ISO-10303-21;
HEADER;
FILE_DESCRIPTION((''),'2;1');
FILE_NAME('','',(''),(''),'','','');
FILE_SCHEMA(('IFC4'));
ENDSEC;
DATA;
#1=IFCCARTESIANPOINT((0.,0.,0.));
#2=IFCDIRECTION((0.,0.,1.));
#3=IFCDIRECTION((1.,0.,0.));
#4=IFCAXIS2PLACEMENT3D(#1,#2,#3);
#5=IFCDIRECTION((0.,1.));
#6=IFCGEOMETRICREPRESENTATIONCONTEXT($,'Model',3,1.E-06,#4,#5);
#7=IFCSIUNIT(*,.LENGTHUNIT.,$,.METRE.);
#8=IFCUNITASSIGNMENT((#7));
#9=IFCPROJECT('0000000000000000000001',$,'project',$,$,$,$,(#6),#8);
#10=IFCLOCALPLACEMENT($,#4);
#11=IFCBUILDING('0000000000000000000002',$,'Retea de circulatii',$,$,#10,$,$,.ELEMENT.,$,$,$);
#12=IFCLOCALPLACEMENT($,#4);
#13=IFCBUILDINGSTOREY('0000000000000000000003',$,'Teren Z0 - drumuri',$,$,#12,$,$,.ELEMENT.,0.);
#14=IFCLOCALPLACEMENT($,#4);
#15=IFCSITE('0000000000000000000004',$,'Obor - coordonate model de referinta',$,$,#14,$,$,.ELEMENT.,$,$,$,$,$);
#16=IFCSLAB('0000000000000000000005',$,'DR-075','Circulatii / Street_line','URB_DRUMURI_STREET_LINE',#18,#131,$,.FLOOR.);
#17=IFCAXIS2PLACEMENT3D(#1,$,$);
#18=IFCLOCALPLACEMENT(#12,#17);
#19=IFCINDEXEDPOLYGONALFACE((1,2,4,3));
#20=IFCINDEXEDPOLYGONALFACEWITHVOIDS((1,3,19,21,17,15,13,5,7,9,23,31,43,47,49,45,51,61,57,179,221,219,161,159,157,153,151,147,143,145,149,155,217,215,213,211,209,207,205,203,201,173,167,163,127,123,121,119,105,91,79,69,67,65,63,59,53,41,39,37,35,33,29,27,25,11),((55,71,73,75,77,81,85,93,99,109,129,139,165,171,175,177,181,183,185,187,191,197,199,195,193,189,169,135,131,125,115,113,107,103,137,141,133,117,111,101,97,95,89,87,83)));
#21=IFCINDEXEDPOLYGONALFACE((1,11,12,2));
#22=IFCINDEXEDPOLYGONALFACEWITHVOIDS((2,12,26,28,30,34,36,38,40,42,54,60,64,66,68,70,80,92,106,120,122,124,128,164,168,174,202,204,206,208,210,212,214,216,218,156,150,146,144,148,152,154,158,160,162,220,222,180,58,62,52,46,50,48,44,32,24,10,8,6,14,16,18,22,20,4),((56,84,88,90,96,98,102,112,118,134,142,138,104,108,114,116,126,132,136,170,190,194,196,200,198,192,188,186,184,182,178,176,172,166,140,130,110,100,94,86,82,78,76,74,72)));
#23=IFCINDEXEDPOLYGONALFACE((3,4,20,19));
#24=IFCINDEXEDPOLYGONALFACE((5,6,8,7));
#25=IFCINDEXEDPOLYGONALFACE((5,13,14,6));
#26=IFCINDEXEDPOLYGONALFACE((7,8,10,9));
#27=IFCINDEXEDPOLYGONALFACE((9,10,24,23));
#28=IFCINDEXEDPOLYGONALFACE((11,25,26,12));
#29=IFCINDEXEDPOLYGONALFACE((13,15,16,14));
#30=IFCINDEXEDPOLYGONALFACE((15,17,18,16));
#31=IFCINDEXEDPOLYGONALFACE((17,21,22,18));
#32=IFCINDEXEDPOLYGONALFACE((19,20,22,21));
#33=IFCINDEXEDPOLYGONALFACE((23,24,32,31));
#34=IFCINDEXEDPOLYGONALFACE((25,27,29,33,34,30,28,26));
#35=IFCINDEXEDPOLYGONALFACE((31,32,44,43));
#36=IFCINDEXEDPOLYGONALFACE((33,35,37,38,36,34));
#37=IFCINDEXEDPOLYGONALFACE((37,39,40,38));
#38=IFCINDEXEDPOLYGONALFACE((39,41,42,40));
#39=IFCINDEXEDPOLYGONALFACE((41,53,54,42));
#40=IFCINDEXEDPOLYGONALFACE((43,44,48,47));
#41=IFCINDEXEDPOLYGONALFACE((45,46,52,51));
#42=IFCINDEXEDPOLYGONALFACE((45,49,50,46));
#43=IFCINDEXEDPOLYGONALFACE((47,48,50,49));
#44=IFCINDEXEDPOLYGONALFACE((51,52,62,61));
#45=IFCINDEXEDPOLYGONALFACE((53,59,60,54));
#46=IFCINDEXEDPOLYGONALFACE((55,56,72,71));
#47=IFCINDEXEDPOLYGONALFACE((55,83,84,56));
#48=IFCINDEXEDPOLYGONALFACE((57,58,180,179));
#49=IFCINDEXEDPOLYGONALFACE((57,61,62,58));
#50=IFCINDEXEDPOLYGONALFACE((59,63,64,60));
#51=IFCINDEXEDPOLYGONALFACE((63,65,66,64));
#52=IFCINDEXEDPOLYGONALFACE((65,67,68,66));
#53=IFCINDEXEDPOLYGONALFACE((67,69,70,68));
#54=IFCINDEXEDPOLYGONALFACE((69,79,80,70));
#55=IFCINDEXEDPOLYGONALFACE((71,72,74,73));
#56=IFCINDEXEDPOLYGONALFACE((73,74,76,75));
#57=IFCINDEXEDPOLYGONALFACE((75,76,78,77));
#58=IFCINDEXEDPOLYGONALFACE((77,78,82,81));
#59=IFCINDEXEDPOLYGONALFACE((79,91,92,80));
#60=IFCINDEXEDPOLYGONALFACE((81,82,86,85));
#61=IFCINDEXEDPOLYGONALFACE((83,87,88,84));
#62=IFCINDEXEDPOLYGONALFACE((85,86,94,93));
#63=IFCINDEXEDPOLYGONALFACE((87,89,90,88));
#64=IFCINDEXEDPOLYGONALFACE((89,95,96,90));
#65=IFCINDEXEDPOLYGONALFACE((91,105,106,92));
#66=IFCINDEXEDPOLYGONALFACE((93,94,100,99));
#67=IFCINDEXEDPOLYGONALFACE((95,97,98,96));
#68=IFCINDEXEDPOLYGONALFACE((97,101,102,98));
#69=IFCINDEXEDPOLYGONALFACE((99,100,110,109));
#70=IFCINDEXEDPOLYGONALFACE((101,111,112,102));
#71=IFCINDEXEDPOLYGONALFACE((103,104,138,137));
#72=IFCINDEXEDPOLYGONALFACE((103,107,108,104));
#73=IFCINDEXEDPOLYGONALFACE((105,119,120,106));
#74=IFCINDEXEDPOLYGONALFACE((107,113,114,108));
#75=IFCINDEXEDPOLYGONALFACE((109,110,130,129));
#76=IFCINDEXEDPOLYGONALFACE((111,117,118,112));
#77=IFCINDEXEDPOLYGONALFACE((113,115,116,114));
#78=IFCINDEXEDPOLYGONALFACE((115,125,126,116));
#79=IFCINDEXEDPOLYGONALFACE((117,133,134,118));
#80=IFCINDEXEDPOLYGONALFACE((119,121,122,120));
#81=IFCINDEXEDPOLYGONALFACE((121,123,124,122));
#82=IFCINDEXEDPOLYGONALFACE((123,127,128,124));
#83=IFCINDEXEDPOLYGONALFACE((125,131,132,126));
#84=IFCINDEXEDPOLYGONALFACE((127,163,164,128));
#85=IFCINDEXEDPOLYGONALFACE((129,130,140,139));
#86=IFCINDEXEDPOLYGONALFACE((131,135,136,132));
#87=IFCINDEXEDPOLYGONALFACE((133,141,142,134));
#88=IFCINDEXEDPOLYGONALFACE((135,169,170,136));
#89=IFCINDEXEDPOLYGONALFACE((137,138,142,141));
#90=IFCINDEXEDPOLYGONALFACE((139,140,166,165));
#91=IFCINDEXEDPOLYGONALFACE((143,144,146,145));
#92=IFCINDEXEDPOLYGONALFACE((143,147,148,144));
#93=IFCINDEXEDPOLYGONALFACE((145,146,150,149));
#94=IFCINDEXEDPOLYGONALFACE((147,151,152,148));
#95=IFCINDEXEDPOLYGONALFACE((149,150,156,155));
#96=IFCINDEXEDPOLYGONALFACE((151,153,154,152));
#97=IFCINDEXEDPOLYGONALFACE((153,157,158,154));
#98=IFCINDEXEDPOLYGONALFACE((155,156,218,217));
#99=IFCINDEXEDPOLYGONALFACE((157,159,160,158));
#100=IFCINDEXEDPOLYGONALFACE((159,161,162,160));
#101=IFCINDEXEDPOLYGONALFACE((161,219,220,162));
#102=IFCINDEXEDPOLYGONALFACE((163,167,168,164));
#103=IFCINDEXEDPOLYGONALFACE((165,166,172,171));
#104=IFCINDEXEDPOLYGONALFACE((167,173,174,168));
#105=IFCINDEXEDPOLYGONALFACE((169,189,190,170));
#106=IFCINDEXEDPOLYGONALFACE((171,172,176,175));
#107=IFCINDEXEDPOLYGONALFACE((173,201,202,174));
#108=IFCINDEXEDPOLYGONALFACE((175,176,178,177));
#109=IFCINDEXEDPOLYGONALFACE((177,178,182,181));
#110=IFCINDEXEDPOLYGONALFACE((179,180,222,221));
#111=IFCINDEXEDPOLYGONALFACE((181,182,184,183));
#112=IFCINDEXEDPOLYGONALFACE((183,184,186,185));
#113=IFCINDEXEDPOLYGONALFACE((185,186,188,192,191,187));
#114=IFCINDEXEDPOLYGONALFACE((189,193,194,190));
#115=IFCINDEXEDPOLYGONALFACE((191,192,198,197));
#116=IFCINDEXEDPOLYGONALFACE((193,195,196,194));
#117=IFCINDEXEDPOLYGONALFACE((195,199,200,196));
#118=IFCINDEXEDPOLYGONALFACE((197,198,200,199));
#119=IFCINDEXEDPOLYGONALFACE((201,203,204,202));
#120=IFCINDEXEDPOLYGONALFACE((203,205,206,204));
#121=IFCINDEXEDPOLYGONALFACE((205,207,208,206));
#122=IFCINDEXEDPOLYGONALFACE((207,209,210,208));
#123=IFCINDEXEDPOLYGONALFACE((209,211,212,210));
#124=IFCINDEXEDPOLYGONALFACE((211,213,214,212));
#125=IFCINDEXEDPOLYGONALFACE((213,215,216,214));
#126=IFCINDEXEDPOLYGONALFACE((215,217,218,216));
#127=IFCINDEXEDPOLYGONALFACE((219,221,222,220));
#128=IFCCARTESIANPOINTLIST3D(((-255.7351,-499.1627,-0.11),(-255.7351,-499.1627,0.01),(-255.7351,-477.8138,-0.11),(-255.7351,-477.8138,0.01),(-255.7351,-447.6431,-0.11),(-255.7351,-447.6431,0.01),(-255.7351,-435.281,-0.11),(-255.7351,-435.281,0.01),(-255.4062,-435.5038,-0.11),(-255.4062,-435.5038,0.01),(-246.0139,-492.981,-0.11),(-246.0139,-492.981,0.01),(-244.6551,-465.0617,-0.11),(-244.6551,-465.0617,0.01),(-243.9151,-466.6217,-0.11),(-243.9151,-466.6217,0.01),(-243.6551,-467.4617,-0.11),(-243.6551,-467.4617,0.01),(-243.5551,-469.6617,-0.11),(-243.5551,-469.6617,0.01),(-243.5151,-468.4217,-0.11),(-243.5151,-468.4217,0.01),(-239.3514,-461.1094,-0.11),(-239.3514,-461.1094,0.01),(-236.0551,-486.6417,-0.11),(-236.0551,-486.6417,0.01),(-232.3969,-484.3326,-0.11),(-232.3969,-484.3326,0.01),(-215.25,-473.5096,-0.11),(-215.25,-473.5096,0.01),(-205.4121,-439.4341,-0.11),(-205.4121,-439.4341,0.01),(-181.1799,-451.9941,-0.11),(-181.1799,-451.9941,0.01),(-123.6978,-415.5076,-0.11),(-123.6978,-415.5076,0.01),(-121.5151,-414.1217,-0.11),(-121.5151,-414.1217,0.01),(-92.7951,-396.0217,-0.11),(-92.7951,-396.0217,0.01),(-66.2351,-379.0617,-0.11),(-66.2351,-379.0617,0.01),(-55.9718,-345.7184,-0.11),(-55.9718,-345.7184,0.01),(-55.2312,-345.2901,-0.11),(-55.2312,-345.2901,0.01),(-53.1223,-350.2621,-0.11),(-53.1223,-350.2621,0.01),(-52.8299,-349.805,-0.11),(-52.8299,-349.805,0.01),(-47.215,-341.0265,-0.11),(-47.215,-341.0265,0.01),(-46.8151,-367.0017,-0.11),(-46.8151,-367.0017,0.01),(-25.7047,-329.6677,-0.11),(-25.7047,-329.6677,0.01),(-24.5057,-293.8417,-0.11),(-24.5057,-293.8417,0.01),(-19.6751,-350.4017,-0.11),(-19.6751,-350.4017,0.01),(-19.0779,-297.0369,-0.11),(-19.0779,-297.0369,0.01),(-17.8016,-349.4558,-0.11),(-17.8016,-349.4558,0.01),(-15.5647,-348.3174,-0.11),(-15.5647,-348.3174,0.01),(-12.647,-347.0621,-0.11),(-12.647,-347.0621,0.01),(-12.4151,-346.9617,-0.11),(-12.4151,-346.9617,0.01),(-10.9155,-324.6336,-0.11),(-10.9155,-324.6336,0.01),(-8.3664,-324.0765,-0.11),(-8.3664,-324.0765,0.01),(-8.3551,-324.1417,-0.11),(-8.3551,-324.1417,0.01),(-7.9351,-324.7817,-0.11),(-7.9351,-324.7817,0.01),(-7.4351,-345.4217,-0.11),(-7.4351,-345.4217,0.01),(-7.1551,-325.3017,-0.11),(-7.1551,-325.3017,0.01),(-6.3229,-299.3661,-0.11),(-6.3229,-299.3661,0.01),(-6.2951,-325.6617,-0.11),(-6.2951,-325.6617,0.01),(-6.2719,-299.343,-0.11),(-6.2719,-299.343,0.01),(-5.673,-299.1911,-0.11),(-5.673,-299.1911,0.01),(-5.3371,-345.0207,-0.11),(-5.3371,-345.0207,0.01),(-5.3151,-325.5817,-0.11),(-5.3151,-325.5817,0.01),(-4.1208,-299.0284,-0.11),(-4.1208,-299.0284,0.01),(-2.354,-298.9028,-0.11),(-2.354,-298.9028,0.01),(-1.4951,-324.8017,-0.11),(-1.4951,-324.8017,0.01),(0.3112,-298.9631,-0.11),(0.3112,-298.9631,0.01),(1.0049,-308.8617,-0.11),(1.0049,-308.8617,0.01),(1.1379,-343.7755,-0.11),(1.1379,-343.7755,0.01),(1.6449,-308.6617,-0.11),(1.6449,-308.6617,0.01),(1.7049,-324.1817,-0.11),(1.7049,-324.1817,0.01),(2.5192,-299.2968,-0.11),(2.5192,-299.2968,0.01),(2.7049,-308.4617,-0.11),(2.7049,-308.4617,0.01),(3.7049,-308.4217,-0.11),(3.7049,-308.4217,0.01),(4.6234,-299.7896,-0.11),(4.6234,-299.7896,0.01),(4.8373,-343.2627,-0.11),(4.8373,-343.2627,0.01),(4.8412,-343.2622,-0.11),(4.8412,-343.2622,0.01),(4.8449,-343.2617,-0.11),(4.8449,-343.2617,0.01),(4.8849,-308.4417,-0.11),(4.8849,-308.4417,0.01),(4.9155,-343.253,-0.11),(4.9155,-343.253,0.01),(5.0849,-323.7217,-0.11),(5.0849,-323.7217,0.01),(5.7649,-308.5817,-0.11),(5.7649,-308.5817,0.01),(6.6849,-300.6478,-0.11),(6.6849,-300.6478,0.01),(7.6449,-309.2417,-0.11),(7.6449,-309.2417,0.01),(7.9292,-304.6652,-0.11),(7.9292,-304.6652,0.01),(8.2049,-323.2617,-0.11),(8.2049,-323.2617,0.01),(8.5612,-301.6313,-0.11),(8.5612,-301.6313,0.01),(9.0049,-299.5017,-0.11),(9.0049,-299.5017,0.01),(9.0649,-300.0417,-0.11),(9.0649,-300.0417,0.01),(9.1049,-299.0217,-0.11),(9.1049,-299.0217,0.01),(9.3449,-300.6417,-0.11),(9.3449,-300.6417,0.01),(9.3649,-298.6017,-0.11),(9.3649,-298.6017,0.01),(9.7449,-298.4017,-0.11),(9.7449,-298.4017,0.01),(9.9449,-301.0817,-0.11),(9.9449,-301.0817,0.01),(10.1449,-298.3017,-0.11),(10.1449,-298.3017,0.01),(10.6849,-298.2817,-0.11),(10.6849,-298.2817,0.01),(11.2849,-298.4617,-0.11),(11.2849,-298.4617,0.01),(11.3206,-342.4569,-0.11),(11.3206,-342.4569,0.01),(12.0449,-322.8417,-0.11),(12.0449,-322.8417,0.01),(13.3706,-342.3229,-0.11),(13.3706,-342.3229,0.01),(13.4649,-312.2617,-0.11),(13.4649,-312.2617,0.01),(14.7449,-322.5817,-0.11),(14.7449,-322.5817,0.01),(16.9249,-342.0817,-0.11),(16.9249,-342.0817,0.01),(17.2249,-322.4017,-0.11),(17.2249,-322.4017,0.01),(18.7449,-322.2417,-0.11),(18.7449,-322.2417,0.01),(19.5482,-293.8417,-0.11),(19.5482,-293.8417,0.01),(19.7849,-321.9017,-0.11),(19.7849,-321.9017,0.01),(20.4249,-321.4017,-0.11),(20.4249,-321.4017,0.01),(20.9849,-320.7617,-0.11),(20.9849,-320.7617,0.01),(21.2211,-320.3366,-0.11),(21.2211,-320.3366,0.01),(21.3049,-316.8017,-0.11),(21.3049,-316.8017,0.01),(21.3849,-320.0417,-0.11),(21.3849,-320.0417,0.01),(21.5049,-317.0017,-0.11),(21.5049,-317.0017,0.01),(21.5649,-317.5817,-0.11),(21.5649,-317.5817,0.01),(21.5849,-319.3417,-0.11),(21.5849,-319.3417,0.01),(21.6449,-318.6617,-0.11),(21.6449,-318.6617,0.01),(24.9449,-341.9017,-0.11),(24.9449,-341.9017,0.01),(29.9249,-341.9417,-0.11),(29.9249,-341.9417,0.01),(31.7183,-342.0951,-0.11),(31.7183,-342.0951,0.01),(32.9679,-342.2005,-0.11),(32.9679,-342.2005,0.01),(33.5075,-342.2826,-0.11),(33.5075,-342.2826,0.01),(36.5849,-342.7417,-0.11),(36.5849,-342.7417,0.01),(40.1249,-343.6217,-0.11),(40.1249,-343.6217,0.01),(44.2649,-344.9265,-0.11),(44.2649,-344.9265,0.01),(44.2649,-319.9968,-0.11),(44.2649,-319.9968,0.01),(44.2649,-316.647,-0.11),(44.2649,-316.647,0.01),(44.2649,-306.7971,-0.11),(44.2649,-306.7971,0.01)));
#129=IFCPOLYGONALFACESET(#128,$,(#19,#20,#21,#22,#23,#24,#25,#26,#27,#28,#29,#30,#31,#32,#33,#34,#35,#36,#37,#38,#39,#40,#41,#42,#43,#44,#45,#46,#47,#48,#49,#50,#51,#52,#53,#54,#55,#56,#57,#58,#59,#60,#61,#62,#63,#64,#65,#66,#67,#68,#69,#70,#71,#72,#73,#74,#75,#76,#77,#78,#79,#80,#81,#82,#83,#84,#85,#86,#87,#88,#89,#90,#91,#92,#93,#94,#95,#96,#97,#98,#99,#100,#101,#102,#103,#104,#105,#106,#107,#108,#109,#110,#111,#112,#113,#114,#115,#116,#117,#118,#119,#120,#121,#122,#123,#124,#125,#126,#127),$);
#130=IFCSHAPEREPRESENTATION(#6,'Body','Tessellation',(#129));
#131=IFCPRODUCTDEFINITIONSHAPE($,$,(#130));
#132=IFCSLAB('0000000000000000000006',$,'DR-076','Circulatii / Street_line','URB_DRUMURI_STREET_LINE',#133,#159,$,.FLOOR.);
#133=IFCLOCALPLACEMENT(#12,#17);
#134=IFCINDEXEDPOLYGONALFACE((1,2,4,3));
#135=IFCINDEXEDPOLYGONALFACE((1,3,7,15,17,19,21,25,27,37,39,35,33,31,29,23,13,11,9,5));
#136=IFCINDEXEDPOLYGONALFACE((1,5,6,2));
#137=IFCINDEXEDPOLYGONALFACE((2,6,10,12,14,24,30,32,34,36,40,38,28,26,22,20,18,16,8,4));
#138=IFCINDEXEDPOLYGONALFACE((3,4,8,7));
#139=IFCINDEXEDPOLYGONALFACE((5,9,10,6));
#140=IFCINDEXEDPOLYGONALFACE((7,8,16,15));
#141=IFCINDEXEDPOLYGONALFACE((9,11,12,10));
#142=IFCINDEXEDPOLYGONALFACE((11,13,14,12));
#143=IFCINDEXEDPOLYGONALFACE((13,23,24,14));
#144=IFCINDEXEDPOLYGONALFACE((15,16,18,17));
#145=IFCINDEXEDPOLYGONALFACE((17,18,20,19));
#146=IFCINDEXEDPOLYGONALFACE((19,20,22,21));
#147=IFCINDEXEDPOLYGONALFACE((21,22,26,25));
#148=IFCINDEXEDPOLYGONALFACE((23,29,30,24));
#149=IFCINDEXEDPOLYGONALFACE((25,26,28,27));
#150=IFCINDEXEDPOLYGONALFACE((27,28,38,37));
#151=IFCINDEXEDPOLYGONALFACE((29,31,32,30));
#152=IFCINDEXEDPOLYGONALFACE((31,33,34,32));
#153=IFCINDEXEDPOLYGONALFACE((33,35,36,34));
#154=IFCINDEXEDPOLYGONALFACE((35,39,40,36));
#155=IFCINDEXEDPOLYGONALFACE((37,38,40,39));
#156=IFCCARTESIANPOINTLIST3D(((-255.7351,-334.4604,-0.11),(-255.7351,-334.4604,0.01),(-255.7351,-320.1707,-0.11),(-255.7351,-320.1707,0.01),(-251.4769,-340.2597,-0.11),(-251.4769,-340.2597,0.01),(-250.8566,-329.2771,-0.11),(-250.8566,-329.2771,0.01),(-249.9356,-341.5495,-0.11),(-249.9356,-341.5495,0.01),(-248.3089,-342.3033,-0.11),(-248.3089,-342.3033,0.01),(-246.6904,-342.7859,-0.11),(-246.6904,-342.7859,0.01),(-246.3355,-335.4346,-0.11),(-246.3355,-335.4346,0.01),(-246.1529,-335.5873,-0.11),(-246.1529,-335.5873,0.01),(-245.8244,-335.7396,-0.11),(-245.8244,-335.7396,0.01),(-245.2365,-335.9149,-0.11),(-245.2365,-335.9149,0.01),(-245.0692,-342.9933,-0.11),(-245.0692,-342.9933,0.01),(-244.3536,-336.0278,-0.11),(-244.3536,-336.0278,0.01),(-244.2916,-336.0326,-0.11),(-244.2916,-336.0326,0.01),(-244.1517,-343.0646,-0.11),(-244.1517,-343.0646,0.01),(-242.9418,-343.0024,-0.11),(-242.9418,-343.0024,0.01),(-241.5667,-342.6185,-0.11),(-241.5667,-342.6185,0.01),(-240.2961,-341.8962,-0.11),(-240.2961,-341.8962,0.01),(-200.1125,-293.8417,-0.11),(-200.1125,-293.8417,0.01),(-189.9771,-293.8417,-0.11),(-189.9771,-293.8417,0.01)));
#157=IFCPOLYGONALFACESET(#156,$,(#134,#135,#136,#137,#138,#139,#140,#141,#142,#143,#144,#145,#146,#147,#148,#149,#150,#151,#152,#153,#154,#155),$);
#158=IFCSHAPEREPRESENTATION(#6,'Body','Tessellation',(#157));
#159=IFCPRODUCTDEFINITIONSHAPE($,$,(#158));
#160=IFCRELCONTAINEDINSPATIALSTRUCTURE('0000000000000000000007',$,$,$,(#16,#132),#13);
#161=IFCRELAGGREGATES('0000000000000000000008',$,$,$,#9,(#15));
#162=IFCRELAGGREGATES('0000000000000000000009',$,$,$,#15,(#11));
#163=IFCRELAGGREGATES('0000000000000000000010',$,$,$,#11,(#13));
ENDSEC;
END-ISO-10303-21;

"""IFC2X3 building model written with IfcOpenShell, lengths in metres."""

from ifc_helpers import new_model, si_unit, direction, frame, origin_with_axes, place, context, project, spatial, polyline, outline, extrude, element, save


model = new_model("IFC2X3")

# Units and contexts
model_context = context("Model", 3, precision=1e-06, world=origin_with_axes(), true_north=direction((0.0, 1.0)))
ifc_project = project(units=[si_unit("LENGTHUNIT", "METRE")], contexts=[model_context])

# Site, building, storey
site_placement = place(None, origin_with_axes())
site = spatial("IfcSite", under=ifc_project, at=site_placement, Name="Obor - coordonate model de referinta", CompositionType="ELEMENT")
building_placement = place(None, origin_with_axes())
building = spatial("IfcBuilding", under=site, at=building_placement, Name="Retea de circulatii", CompositionType="ELEMENT")
storey_placement = place(None, origin_with_axes())
storey = spatial("IfcBuildingStorey", under=building, at=storey_placement, Name="Teren Z0 - drumuri", CompositionType="ELEMENT", Elevation=0.0)

# Slabs
slab_1_placement = place(None, origin_with_axes())
element("IfcSlab", 1, at=slab_1_placement, inside=storey, Name="DR-075", Description="Circulatii / Street_line", ObjectType="URB_DRUMURI_STREET_LINE", PredefinedType="FLOOR", context=model_context, shape_type="SweptSolid", body=[
    extrude(outline(polyline([(11.2849, -298.4617), (44.2649, -316.647), (44.2649, -306.7971), (19.5482, -293.8417), (-24.5057, -293.8417), (-19.0779, -297.0369), (-47.215, -341.0265), (-55.2312, -345.2901), (-52.8299, -349.805), (-53.1223, -350.2621), (-55.9718, -345.7184), (-205.4121, -439.4341), (-239.3514, -461.1094), (-255.4062, -435.5038), (-255.7351, -435.281), (-255.7351, -447.6431), (-244.6551, -465.0617), (-243.9151, -466.6217), (-243.6551, -467.4617), (-243.5151, -468.4217), (-243.5551, -469.6617), (-255.7351, -477.8138), (-255.7351, -499.1627), (-246.0139, -492.981), (-236.0551, -486.6417), (-232.3969, -484.3326), (-215.25, -473.5096), (-181.1799, -451.9941), (-123.6978, -415.5076), (-121.5151, -414.1217), (-92.7951, -396.0217), (-66.2351, -379.0617), (-46.8151, -367.0017), (-19.6751, -350.4017), (-17.8016, -349.4558), (-15.5647, -348.3174), (-12.647, -347.0621), (-12.4151, -346.9617), (-7.4351, -345.4217), (-5.3371, -345.0207), (1.1379, -343.7755), (4.8373, -343.2627), (4.8412, -343.2622), (4.8449, -343.2617), (4.9155, -343.253), (11.3206, -342.4569), (13.3706, -342.3229), (16.9249, -342.0817), (24.9449, -341.9017), (29.9249, -341.9417), (31.7183, -342.0951), (32.9679, -342.2005), (33.5075, -342.2826), (36.5849, -342.7417), (40.1249, -343.6217), (44.2649, -344.9265), (44.2649, -319.9968), (9.9449, -301.0817), (9.3449, -300.6417), (9.0649, -300.0417), (9.0049, -299.5017), (9.1049, -299.0217), (9.3649, -298.6017), (9.7449, -298.4017), (10.1449, -298.3017), (10.6849, -298.2817), (11.2849, -298.4617)]), holes=[polyline([(-5.673, -299.1911), (-4.1208, -299.0284), (-2.354, -298.9028), (0.3112, -298.9631), (2.5192, -299.2968), (4.6234, -299.7896), (6.6849, -300.6478), (8.5612, -301.6313), (7.9292, -304.6652), (1.0049, -308.8617), (1.6449, -308.6617), (2.7049, -308.4617), (3.7049, -308.4217), (4.8849, -308.4417), (5.7649, -308.5817), (7.6449, -309.2417), (13.4649, -312.2617), (21.3049, -316.8017), (21.5049, -317.0017), (21.5649, -317.5817), (21.6449, -318.6617), (21.5849, -319.3417), (21.3849, -320.0417), (21.2211, -320.3366), (20.9849, -320.7617), (20.4249, -321.4017), (19.7849, -321.9017), (18.7449, -322.2417), (17.2249, -322.4017), (14.7449, -322.5817), (12.0449, -322.8417), (8.2049, -323.2617), (5.0849, -323.7217), (1.7049, -324.1817), (-1.4951, -324.8017), (-5.3151, -325.5817), (-6.2951, -325.6617), (-7.1551, -325.3017), (-7.9351, -324.7817), (-8.3551, -324.1417), (-8.3551, -324.1417), (-8.3664, -324.0765), (-10.9155, -324.6336), (-25.7047, -329.6677), (-6.3229, -299.3661), (-6.2719, -299.343), (-5.673, -299.1911)])]), frame((0.0, 0.0, -0.11), z_axis=(0.0, 0.0, 1.0), x_axis=(1.0, 0.0, 0.0)), (0.0, 0.0, 1.0), 0.12),
])
slab_2_placement = place(None, origin_with_axes())
element("IfcSlab", 2, at=slab_2_placement, inside=storey, Name="DR-076", Description="Circulatii / Street_line", ObjectType="URB_DRUMURI_STREET_LINE", PredefinedType="FLOOR", context=model_context, shape_type="SweptSolid", body=[
    extrude(outline(polyline([(-242.9418, -343.0024), (-241.5667, -342.6185), (-240.2961, -341.8962), (-189.9771, -293.8417), (-200.1125, -293.8417), (-244.2916, -336.0326), (-244.3536, -336.0278), (-245.2365, -335.9149), (-245.8244, -335.7396), (-246.1529, -335.5873), (-246.3355, -335.4346), (-250.8566, -329.2771), (-255.7351, -320.1707), (-255.7351, -334.4604), (-251.4769, -340.2597), (-249.9356, -341.5495), (-248.3089, -342.3033), (-246.6904, -342.7859), (-245.0692, -342.9933), (-244.1517, -343.0646), (-242.9418, -343.0024)])), frame((0.0, 0.0, -0.11), z_axis=(0.0, 0.0, 1.0), x_axis=(1.0, 0.0, 0.0)), (0.0, 0.0, 1.0), 0.12),
])

save(model, "model.ifc")
